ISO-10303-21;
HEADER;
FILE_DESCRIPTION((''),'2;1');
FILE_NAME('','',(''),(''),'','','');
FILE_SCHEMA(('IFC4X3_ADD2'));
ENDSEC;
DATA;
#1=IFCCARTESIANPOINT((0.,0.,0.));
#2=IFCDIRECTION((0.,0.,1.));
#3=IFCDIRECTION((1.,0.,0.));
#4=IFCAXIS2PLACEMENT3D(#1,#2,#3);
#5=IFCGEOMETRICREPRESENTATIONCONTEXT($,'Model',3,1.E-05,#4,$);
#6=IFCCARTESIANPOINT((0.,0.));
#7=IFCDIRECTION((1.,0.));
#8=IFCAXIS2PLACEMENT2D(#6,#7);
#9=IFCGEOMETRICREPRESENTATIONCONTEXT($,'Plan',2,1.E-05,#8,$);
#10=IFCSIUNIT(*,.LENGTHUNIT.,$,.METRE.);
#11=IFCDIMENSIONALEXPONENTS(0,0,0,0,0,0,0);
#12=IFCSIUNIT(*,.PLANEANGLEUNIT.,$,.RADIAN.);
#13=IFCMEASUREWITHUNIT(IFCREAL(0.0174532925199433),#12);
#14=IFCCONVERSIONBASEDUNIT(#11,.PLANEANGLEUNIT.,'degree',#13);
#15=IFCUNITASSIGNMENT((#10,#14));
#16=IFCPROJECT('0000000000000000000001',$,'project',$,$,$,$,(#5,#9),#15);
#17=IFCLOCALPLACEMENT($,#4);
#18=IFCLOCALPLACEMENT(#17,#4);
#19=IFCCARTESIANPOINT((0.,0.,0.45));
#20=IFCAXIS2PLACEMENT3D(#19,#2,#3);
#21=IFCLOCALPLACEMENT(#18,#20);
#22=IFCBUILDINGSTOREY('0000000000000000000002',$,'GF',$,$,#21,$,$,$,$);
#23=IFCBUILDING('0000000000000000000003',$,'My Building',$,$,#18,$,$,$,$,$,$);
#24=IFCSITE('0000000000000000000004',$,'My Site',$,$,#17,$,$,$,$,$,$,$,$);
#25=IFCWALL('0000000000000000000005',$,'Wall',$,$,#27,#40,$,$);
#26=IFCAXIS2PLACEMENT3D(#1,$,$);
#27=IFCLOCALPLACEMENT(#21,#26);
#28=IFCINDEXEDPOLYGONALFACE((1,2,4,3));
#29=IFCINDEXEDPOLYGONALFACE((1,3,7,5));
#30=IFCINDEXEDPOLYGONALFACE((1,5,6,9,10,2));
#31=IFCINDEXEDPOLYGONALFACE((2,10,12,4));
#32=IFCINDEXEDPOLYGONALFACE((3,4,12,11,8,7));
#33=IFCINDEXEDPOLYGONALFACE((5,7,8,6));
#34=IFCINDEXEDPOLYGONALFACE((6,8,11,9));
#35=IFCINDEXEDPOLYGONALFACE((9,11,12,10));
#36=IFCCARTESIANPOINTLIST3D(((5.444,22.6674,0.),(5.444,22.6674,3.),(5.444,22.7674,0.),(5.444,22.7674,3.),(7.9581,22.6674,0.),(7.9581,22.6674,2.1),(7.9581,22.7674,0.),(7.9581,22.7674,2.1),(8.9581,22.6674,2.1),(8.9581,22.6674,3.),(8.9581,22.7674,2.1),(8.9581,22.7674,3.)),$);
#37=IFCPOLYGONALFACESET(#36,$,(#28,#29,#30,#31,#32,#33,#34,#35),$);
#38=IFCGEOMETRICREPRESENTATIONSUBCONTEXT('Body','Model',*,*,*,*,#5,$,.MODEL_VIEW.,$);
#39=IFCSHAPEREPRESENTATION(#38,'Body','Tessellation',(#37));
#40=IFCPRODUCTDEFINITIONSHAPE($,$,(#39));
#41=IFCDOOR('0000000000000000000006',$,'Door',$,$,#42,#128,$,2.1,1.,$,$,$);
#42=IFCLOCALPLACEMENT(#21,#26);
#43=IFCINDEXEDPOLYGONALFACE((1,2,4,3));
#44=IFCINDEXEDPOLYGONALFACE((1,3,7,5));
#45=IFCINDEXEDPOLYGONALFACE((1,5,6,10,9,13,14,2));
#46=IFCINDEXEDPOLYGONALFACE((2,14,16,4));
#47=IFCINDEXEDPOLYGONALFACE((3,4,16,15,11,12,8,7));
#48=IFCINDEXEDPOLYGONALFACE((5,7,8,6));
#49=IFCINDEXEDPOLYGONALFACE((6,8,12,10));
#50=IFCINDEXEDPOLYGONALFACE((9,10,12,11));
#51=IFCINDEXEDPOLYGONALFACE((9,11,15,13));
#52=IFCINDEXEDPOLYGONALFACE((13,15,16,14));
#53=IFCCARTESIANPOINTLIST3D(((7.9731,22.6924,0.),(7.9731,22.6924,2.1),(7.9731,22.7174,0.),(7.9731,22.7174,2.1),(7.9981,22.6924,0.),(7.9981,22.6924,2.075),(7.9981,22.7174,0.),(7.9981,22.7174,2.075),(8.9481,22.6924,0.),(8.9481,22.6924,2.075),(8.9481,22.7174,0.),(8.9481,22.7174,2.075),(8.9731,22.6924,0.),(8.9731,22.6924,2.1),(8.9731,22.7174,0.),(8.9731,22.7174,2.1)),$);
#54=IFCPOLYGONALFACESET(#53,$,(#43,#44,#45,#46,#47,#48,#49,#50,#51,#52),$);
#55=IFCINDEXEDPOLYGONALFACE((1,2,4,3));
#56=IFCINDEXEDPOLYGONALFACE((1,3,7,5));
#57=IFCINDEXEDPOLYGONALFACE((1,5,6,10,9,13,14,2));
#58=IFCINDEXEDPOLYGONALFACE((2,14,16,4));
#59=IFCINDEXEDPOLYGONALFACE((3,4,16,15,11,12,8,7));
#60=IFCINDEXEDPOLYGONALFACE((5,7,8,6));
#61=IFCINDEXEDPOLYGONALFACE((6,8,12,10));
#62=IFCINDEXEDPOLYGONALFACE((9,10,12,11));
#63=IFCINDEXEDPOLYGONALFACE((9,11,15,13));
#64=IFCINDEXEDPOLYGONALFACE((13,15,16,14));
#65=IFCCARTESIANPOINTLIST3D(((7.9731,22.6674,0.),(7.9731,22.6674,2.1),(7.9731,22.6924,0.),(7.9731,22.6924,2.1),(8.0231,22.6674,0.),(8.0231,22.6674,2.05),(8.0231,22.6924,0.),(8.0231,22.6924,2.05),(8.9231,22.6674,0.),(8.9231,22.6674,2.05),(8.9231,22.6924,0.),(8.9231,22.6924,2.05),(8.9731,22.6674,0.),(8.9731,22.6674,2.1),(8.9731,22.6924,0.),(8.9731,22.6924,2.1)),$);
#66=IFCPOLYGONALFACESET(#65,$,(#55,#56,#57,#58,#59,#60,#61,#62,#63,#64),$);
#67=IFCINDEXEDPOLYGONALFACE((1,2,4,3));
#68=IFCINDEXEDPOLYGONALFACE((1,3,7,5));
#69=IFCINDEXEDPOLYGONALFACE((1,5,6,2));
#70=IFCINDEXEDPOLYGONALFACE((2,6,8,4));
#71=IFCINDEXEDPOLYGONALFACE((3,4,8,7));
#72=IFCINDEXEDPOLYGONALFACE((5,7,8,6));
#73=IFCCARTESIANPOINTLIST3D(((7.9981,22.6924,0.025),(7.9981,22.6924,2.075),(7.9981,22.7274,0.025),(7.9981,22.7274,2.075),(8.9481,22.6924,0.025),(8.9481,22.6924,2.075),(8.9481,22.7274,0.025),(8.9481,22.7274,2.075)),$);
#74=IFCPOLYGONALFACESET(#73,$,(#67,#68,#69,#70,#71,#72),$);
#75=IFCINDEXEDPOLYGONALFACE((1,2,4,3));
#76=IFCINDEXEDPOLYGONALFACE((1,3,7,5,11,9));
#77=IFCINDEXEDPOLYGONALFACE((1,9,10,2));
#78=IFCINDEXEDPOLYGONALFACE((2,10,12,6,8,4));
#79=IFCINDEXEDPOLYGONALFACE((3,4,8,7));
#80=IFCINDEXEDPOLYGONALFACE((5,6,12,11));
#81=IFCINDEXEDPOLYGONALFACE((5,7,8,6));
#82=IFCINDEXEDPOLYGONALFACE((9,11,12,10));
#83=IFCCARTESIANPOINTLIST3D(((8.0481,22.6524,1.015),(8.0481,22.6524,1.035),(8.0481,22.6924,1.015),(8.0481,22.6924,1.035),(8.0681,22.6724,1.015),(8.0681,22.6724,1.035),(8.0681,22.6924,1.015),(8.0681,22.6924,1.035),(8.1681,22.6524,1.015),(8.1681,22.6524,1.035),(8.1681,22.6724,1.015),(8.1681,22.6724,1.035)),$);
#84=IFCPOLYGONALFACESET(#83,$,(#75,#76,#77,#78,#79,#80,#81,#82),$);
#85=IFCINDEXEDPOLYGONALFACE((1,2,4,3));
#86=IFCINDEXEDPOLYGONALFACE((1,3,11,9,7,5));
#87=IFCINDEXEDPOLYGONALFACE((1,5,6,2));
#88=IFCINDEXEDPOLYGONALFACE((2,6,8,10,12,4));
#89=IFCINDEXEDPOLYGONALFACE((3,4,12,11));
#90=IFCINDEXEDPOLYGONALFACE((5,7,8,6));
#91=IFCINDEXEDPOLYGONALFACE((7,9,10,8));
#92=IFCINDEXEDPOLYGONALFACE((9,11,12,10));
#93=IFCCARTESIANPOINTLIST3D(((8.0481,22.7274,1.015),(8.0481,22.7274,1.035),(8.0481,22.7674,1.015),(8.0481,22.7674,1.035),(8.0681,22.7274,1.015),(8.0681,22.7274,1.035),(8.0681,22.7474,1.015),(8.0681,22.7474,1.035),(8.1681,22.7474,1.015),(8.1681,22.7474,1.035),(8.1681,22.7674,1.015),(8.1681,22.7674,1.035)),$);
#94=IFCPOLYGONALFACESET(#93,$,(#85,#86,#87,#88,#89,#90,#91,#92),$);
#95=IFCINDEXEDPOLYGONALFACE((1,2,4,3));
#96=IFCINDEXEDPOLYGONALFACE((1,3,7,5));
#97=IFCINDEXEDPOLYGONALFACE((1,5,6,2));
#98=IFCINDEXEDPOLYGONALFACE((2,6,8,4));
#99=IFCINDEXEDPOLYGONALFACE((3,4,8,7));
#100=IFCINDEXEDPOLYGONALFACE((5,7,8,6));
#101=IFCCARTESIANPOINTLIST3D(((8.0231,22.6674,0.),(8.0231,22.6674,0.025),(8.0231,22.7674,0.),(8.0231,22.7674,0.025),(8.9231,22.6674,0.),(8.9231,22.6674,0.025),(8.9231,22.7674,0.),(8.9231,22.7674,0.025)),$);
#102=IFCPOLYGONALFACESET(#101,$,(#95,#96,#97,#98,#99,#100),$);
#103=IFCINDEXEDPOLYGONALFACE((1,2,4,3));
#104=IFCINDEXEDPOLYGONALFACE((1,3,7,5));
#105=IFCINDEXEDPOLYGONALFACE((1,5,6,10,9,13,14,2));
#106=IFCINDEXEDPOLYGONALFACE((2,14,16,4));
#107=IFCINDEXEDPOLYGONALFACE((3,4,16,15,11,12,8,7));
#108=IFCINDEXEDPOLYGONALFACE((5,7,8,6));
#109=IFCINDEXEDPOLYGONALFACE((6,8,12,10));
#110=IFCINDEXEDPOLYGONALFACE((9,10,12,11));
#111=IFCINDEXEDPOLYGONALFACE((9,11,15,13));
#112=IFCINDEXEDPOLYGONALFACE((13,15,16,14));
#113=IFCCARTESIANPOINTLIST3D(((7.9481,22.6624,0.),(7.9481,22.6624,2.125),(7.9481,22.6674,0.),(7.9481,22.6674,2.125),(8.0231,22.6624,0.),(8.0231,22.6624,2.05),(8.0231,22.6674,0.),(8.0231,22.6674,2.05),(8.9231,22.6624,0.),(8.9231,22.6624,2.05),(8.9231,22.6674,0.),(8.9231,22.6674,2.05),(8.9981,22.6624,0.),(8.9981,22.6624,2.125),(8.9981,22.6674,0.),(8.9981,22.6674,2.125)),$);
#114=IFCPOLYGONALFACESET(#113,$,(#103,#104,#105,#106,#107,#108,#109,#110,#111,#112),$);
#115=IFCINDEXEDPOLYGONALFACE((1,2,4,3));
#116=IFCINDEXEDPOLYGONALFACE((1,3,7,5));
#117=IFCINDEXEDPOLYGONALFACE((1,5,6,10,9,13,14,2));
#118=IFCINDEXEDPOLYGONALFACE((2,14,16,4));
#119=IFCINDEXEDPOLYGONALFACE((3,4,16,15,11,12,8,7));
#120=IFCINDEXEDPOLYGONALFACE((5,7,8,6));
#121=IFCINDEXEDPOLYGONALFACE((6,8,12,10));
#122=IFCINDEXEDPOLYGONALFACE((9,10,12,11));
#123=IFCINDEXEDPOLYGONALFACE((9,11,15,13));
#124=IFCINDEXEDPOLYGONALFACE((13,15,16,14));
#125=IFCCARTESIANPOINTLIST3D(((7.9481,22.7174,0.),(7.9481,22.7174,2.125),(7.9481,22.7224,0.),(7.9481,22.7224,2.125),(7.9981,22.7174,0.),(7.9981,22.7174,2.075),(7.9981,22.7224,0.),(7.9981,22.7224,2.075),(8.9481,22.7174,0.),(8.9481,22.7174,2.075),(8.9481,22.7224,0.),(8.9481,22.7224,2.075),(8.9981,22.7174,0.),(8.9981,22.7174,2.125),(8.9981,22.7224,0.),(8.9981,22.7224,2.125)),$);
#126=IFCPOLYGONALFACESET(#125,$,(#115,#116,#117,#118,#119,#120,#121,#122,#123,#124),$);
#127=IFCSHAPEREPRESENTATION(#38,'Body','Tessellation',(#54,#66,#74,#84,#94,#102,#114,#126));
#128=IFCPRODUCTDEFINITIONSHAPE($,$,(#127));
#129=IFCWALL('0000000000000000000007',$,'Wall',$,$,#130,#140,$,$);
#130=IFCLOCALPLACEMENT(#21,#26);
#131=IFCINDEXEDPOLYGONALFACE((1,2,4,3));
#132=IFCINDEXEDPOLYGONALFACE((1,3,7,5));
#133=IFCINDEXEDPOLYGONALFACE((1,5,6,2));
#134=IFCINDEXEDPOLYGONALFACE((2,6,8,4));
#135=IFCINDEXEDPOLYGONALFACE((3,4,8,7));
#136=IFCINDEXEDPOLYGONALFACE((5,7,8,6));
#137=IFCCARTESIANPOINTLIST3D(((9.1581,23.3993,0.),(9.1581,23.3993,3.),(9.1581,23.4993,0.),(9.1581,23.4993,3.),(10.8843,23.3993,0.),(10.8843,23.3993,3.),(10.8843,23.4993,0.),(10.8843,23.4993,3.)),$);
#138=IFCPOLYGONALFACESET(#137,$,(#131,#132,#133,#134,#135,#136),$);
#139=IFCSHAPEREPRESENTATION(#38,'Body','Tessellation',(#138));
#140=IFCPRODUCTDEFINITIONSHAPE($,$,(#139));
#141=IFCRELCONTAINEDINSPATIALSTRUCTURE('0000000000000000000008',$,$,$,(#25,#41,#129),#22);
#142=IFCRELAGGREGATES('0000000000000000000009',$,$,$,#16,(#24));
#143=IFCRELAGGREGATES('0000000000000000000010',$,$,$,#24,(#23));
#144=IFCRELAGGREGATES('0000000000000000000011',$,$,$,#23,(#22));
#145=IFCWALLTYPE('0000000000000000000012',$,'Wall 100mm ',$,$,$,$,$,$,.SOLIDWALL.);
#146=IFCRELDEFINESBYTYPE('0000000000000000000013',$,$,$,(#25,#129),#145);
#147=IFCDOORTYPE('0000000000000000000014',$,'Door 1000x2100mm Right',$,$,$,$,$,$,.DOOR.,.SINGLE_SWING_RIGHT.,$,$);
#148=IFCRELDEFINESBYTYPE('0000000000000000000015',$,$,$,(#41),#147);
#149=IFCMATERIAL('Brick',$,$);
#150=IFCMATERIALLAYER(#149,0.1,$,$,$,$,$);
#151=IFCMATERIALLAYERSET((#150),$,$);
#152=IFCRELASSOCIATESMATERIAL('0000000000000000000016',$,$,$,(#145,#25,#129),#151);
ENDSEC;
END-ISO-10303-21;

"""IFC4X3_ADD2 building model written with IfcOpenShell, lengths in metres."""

from ifc_helpers import new_model, entity, si_unit, converted_unit, frame, origin_with_axes, origin_2d_with_axis, place, context, subcontext, project, spatial, line, indexed_curve, outline, extrude, shape, source, transform, mapped, material, layer, layer_set, layer_usage, type_object, type_shapes, element, fill, save


model = new_model("IFC4X3_ADD2")

# Units and contexts
model_context = context("Model", 3, precision=1e-05, world=origin_with_axes())
plan_context = context("Plan", 2, precision=1e-05, world=origin_2d_with_axis())
body_context_1 = subcontext(model_context, "Body", "Model", "MODEL_VIEW")
body_context_2 = subcontext(plan_context, "Body", "Plan", "PLAN_VIEW")
ifc_project = project(units=[si_unit("LENGTHUNIT", "METRE"), converted_unit("PLANEANGLEUNIT", "degree", entity("IfcReal", 0.0174532925199433), si_unit("PLANEANGLEUNIT", "RADIAN"), dimensions=[0, 0, 0, 0, 0, 0, 0])], contexts=[model_context, plan_context])

# Site, building, storey
site_placement = place(None, origin_with_axes())
site = spatial("IfcSite", under=ifc_project, at=site_placement, Name="My Site")
building_placement = place(site_placement, origin_with_axes())
building = spatial("IfcBuilding", under=site, at=building_placement, Name="My Building")
storey_placement = place(building_placement, frame((0.0, 0.0, 0.45), z_axis=(0.0, 0.0, 1.0), x_axis=(1.0, 0.0, 0.0)))
storey = spatial("IfcBuildingStorey", under=building, at=storey_placement, Name="GF")

# Shared definitions
ifc_material = material(Name="Brick")

# Wall, opening, door
ifc_layer_1 = layer(ifc_material, 0.1)
ifc_layer_set_1 = layer_set([ifc_layer_1])
ifc_layer_usage_1 = layer_usage(ifc_layer_set_1, "AXIS2", "POSITIVE", 0.0)
wall_type_1 = type_object("IfcWallType", Name="Wall 100mm ", PredefinedType="SOLIDWALL", material=ifc_layer_set_1)
wall_1_placement = place(storey_placement, frame((5.444, 22.6674, 0.0), z_axis=(0.0, 0.0, 1.0), x_axis=(1.0, 0.0, 0.0)))
wall_1 = element("IfcWall", 1, at=wall_1_placement, inside=storey, type_object=wall_type_1, material=ifc_layer_usage_1, Name="Wall", context=body_context_1, shape_type="SweptSolid", body=[
    extrude(outline(indexed_curve([(0.0, 0.0), (0.0, 0.1), (3.5141, 0.1), (3.5141, 0.0), (0.0, 0.0)], self_intersect=False)), origin_with_axes(), (0.0, 0.0, 1.0), 3.0),
])
shared_shape_1 = source(origin_with_axes(), body_context_1, "Body", "SweptSolid", [
    extrude(outline(indexed_curve([(0.0, 0.0), (1.0, 0.0), (1.0, 2.1), (0.0, 2.1)], segments=[line(1, 2, 3, 4, 1)])), frame((0.0, -0.6, 0.0), z_axis=(0.0, -1.0, 0.0), x_axis=(1.0, 0.0, 0.0)), (0.0, 0.0, -1.0), 1.2),
])
opening_1_placement = place(wall_1_placement, frame((2.5141, 0.0, 0.0), z_axis=(0.0, 0.0, 1.0), x_axis=(1.0, 0.0, 0.0)))
opening_1 = element("IfcOpeningElement", 2, at=opening_1_placement, cuts=wall_1, PredefinedType="OPENING", context=body_context_1, shape_type="MappedRepresentation", body=[
    mapped(shared_shape_1, transform((0.0, 0.0, 0.0), x_axis=(1.0, 0.0, 0.0), y_axis=(0.0, 1.0, 0.0), z_axis=(0.0, 0.0, 1.0), scale=1.0)),
])
door_type_1 = type_object("IfcDoorType", Name="Door 1000x2100mm Right", OperationType="SINGLE_SWING_RIGHT", PredefinedType="DOOR")
shared_shape_2 = source(origin_with_axes(), body_context_1, "Body", "SweptSolid", [
    extrude(outline(indexed_curve([(0.0, 0.0), (0.0, 2.1), (1.0, 2.1), (1.0, 0.0), (0.975, 0.0), (0.975, 2.075), (0.025, 2.075), (0.025, 0.0)], segments=[line(1, 2, 3, 4, 5, 6, 7, 8, 1)])), frame((0.0, 0.025, 0.0), z_axis=(0.0, -1.0, 0.0), x_axis=(1.0, 0.0, 0.0)), (0.0, 0.0, -1.0), 0.025),
    extrude(outline(indexed_curve([(0.0, 0.0), (0.0, 2.1), (1.0, 2.1), (1.0, 0.0), (0.95, 0.0), (0.95, 2.05), (0.05, 2.05), (0.05, 0.0)], segments=[line(1, 2, 3, 4, 5, 6, 7, 8, 1)])), frame((0.0, 0.0, 0.0), z_axis=(0.0, -1.0, 0.0), x_axis=(1.0, 0.0, 0.0)), (0.0, 0.0, -1.0), 0.025),
    extrude(outline(indexed_curve([(0.0, 0.0), (0.95, 0.0), (0.95, 0.035), (0.0, 0.035)], segments=[line(1, 2, 3, 4, 1)])), frame((0.025, 0.025, 0.025), z_axis=(0.0, 0.0, 1.0), x_axis=(1.0, 0.0, 0.0)), (0.0, 0.0, 1.0), 2.05),
    extrude(outline(indexed_curve([(0.0, 0.0), (0.0, -0.04), (0.12, -0.04), (0.12, -0.02), (0.02, -0.02), (0.02, 0.0)], segments=[line(1, 2, 3, 4, 5, 6, 1)])), frame((0.075, 0.025, 1.015), z_axis=(0.0, 0.0, 1.0), x_axis=(1.0, 0.0, 0.0)), (0.0, 0.0, 1.0), 0.02),
    extrude(outline(indexed_curve([(0.0, 0.0), (0.0, 0.04), (0.12, 0.04), (0.12, 0.02), (0.02, 0.02), (0.02, 0.0)], segments=[line(1, 2, 3, 4, 5, 6, 1)])), frame((0.075, 0.06, 1.015), z_axis=(0.0, 0.0, 1.0), x_axis=(1.0, 0.0, 0.0)), (0.0, 0.0, 1.0), 0.02),
    extrude(outline(indexed_curve([(0.0, 0.0), (0.9, 0.0), (0.9, 0.1), (0.0, 0.1)], segments=[line(1, 2, 3, 4, 1)])), frame((0.05, 0.0, 0.0), z_axis=(0.0, 0.0, 1.0), x_axis=(1.0, 0.0, 0.0)), (0.0, 0.0, 1.0), 0.025),
    extrude(outline(indexed_curve([(0.0, 0.0), (0.0, 2.125), (1.05, 2.125), (1.05, 0.0), (0.975, 0.0), (0.975, 2.05), (0.075, 2.05), (0.075, 0.0)], segments=[line(1, 2, 3, 4, 5, 6, 7, 8, 1)])), frame((-0.025, -0.005, 0.0), z_axis=(0.0, -1.0, 0.0), x_axis=(1.0, 0.0, 0.0)), (0.0, 0.0, -1.0), 0.005),
    extrude(outline(indexed_curve([(0.0, 0.0), (0.0, 2.125), (1.05, 2.125), (1.05, 0.0), (1.0, 0.0), (1.0, 2.075), (0.05, 2.075), (0.05, 0.0)], segments=[line(1, 2, 3, 4, 5, 6, 7, 8, 1)])), frame((-0.025, 0.05, 0.0), z_axis=(0.0, -1.0, 0.0), x_axis=(1.0, 0.0, 0.0)), (0.0, 0.0, -1.0), 0.005),
])
shared_shape_3 = source(origin_with_axes(), body_context_2, "Body", "Curve2D", [
    entity("IfcIndexedPolyCurve", entity("IfcCartesianPointList2D", [[0.0, 0.0], [0.0, 0.05], [0.025, 0.05], [0.025, 0.025], [0.05, 0.025], [0.05, 0.0]]), [entity("IfcLineIndex", [1, 2, 3, 4, 5, 6, 1])]),
    entity("IfcIndexedPolyCurve", entity("IfcCartesianPointList2D", [[1.0, 0.0], [1.0, 0.05], [0.975, 0.05], [0.975, 0.025], [0.95, 0.025], [0.95, 0.0]]), [entity("IfcLineIndex", [1, 2, 3, 4, 5, 6, 1])]),
    entity("IfcTrimmedCurve", entity("IfcEllipse", entity("IfcAxis2Placement2D", entity("IfcCartesianPoint", [0.94, 0.05]), entity("IfcDirection", [1.0, 0.0])), 0.915, 0.95), [entity("IfcCartesianPoint", [0.94, 1.0])], [entity("IfcCartesianPoint", [0.025, 0.05])], True, "CARTESIAN"),
    entity("IfcIndexedPolyCurve", entity("IfcCartesianPointList2D", [[0.975, 0.05], [0.94, 0.05], [0.94, 1.0], [0.975, 1.0]]), [entity("IfcLineIndex", [1, 2, 3, 4, 1])]),
])
type_shapes(door_type_1, [shared_shape_2, shared_shape_3])
door_1_placement = place(opening_1_placement, frame((0.015, 0.0, 0.0), z_axis=(0.0, 0.0, 1.0), x_axis=(1.0, 0.0, 0.0)))
door_1 = element("IfcDoor", 3, at=door_1_placement, inside=storey, type_object=door_type_1, Name="Door", OverallHeight=2.1, OverallWidth=1.0, shapes=[
    shape(body_context_1, "Body", "MappedRepresentation", [mapped(shared_shape_2, transform((0.0, 0.0, 0.0), x_axis=(1.0, 0.0, 0.0), y_axis=(0.0, 1.0, 0.0), z_axis=(0.0, 0.0, 1.0), scale=1.0))]),
    shape(body_context_2, "Body", "MappedRepresentation", [mapped(shared_shape_3, transform((0.0, 0.0, 0.0), x_axis=(1.0, 0.0, 0.0), y_axis=(0.0, 1.0, 0.0), z_axis=(0.0, 0.0, 1.0), scale=1.0))]),
])
fill(opening_1, door_1)

# Wall
ifc_layer_usage_2 = layer_usage(ifc_layer_set_1, "AXIS2", "POSITIVE", 0.0)
wall_2_placement = place(storey_placement, frame((9.1581, 23.3993, 0.0), z_axis=(0.0, 0.0, 1.0), x_axis=(1.0, 0.0, 0.0)))
element("IfcWall", 4, at=wall_2_placement, inside=storey, type_object=wall_type_1, material=ifc_layer_usage_2, Name="Wall", context=body_context_1, shape_type="SweptSolid", body=[
    extrude(outline(indexed_curve([(0.0, 0.0), (0.0, 0.1), (1.7262, 0.1), (1.7262, 0.0), (0.0, 0.0)], self_intersect=False)), origin_with_axes(), (0.0, 0.0, 1.0), 3.0),
])

save(model, "model.ifc")
